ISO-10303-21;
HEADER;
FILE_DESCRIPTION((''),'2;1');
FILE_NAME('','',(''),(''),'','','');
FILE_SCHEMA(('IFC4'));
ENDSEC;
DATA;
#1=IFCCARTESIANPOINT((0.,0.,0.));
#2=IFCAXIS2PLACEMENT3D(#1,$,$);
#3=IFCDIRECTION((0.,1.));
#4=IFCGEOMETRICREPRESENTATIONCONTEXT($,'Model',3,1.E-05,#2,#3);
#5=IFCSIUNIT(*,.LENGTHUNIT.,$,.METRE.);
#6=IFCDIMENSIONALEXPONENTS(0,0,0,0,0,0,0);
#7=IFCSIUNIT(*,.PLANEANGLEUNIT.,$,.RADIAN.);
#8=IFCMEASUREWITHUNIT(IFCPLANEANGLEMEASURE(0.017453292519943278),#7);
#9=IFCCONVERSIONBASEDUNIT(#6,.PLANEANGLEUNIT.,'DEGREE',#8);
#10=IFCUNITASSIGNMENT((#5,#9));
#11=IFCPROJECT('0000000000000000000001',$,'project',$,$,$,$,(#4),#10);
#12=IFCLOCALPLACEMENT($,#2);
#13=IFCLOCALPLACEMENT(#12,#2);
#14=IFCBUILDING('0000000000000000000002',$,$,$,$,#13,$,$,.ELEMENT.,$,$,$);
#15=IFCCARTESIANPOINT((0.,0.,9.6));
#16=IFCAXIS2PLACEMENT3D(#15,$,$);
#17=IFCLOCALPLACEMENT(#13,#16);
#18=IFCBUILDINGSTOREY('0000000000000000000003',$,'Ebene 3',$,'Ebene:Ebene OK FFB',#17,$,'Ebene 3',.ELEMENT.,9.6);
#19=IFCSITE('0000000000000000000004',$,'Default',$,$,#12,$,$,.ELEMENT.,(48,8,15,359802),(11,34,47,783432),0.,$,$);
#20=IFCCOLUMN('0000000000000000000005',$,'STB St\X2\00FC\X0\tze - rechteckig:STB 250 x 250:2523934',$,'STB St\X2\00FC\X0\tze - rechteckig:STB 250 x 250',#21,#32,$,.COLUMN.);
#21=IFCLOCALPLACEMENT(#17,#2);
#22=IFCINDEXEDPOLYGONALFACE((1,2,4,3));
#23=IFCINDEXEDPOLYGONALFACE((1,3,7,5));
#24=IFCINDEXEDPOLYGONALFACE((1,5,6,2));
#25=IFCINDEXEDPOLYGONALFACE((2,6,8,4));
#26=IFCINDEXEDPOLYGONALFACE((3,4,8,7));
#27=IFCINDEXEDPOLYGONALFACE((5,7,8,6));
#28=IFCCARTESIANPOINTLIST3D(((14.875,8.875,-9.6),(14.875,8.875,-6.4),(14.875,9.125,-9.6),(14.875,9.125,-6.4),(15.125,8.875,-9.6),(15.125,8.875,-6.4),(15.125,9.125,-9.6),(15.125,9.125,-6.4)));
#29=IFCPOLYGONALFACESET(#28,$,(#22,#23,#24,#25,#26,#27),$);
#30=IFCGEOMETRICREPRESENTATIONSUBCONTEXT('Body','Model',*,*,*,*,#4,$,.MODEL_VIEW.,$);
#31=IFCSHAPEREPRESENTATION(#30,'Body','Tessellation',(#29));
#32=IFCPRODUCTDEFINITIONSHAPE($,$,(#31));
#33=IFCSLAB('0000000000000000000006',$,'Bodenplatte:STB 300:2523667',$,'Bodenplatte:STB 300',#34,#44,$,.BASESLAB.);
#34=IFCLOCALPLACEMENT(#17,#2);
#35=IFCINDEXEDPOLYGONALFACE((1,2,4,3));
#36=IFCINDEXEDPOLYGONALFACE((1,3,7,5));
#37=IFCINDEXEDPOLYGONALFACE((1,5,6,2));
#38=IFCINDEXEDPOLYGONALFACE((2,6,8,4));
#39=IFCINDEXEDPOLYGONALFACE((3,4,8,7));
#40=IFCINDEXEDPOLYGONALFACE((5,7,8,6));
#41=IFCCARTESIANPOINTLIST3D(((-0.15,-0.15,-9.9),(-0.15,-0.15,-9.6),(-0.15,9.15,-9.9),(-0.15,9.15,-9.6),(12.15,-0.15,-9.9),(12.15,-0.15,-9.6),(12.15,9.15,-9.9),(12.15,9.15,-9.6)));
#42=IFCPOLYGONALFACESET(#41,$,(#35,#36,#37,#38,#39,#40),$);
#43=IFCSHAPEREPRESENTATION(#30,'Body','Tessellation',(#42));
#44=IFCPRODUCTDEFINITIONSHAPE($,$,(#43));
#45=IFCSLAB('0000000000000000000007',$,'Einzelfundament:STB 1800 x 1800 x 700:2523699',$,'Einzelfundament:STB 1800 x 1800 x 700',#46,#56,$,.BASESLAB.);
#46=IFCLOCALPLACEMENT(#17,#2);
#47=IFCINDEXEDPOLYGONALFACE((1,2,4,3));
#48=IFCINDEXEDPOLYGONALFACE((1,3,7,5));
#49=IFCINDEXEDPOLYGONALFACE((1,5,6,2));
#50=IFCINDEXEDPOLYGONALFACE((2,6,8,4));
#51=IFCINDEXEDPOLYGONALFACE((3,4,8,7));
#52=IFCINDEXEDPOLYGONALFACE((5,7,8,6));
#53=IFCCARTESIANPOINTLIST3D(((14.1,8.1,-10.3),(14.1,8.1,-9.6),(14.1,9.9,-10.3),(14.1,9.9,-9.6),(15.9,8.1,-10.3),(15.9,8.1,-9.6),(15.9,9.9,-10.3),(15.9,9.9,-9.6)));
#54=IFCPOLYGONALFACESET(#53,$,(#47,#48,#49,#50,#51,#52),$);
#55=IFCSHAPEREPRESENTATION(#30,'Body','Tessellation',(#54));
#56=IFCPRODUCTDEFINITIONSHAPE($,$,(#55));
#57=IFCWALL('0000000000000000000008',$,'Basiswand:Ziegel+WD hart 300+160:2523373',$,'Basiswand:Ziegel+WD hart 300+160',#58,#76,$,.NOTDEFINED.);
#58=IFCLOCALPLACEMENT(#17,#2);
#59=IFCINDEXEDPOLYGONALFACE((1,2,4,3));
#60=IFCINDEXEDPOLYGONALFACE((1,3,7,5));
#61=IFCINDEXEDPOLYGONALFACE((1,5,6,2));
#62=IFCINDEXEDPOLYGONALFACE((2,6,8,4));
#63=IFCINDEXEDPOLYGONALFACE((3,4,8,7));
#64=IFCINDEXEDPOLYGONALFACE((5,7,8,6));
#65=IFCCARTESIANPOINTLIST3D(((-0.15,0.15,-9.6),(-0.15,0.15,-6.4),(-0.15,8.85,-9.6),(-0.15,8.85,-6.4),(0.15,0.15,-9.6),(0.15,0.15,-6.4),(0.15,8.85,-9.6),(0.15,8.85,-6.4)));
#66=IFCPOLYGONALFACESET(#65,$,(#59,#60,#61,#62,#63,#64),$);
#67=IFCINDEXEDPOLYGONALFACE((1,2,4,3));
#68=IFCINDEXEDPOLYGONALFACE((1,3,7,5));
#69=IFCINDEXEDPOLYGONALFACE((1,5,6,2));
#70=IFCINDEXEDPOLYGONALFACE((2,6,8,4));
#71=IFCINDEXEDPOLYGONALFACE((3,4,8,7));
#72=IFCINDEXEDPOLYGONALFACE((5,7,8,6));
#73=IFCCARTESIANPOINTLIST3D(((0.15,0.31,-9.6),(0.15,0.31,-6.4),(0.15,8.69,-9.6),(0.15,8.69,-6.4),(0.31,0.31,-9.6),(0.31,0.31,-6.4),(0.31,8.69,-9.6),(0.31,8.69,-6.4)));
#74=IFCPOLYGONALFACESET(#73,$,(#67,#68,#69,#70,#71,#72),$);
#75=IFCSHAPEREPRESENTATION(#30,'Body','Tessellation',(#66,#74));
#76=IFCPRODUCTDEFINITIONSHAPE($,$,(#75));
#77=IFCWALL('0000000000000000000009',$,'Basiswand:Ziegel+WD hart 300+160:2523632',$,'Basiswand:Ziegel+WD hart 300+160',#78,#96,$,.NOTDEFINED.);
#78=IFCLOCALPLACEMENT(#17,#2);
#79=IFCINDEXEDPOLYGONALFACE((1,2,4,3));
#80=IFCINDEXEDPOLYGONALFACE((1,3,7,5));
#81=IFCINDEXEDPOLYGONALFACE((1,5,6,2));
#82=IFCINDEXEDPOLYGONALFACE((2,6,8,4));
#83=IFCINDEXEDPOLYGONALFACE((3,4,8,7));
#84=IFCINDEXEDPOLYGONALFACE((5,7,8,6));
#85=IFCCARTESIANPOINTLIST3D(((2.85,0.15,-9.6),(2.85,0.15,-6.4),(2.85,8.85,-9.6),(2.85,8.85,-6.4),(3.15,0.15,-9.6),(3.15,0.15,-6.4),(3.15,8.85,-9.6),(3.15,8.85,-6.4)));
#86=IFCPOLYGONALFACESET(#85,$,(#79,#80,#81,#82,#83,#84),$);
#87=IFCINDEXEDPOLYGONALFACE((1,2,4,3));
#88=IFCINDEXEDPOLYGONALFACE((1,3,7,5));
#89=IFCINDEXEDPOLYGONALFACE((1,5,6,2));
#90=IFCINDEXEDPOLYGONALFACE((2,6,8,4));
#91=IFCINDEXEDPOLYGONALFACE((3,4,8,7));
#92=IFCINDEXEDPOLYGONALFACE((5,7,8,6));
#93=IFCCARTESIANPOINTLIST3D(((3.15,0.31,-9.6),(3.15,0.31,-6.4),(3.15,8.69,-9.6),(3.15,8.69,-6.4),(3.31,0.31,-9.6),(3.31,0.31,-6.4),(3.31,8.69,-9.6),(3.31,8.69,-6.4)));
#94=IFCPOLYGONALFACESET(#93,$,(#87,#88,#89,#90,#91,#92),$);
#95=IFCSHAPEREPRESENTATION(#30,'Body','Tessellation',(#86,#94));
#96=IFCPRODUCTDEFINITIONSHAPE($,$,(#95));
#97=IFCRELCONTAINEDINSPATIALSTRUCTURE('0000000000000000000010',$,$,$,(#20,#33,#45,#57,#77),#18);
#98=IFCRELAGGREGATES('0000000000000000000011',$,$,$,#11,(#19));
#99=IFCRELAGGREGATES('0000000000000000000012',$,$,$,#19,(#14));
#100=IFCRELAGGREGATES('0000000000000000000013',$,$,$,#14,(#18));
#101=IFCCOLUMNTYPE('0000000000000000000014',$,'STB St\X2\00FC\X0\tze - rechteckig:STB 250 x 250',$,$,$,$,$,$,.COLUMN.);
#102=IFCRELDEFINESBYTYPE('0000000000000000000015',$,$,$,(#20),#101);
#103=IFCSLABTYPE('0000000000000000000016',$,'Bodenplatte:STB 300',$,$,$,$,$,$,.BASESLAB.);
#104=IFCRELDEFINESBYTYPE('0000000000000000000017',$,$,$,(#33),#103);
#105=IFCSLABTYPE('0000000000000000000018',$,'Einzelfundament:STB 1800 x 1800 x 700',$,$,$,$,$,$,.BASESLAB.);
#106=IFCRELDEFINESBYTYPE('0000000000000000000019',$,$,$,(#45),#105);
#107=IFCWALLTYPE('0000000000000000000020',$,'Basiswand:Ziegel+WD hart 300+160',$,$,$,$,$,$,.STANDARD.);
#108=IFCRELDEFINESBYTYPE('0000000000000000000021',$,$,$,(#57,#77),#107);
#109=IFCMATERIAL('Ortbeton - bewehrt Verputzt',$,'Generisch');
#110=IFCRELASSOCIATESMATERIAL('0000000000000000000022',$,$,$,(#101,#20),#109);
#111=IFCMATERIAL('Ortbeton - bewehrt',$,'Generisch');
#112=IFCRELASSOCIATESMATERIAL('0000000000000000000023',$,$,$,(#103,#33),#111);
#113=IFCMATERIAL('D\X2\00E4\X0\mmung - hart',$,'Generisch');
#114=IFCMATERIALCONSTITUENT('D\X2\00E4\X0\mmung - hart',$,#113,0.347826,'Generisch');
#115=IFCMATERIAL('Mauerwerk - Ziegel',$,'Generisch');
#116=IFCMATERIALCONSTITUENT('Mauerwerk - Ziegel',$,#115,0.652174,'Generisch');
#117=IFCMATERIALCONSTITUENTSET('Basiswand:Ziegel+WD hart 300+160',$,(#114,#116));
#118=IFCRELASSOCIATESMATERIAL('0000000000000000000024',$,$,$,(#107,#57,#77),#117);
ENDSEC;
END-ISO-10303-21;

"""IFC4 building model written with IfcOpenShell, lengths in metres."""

from ifc_helpers import new_model, entity, si_unit, converted_unit, direction, frame, origin, place, context, subcontext, project, spatial, indexed_curve, outline, extrude, source, transform, mapped, material, constituent, constituent_set, type_object, type_shapes, element, save


model = new_model("IFC4")

# Units and contexts
model_context = context("Model", 3, precision=1e-05, world=origin(), true_north=direction((0.0, 1.0)))
body_context = subcontext(model_context, "Body", "Model", "MODEL_VIEW")
ifc_project = project(units=[si_unit("LENGTHUNIT", "METRE"), converted_unit("PLANEANGLEUNIT", "DEGREE", entity("IfcPlaneAngleMeasure", 0.017453292519943278), si_unit("PLANEANGLEUNIT", "RADIAN"), dimensions=[0, 0, 0, 0, 0, 0, 0])], contexts=[model_context])

# Site, building, storey
site_placement = place(None, origin())
site = spatial("IfcSite", under=ifc_project, at=site_placement, Name="Default", CompositionType="ELEMENT", RefLatitude=(48, 8, 15, 359802), RefLongitude=(11, 34, 47, 783432), RefElevation=0.0)
building_placement = place(site_placement, origin())
building = spatial("IfcBuilding", under=site, at=building_placement, CompositionType="ELEMENT")
storey_placement = place(building_placement, frame((0.0, 0.0, 9.6)))
storey = spatial("IfcBuildingStorey", under=building, at=storey_placement, Name="Ebene 3", ObjectType="Ebene:Ebene OK FFB", LongName="Ebene 3", CompositionType="ELEMENT", Elevation=9.6)

# Column
ifc_material_1 = material(Name="Ortbeton - bewehrt Verputzt", Category="Generisch")
column_type = type_object("IfcColumnType", Name="STB Stütze - rechteckig:STB 250 x 250", PredefinedType="COLUMN", material=ifc_material_1)
shared_shape = source(origin(), body_context, "Body", "SweptSolid", [
    extrude(outline(indexed_curve([(-0.125, -0.125), (0.125, -0.125), (0.125, 0.125), (-0.125, 0.125), (-0.125, -0.125)], self_intersect=False)), frame((0.0, 0.0, 0.0), z_axis=(0.0, 0.0, 1.0), x_axis=(-1.0, 0.0, 0.0)), (0.0, 0.0, 1.0), 3.2),
])
type_shapes(column_type, [shared_shape])
column_placement = place(storey_placement, frame((15.0, 9.0, -9.6)))
element("IfcColumn", 1, at=column_placement, inside=storey, type_object=column_type, material=ifc_material_1, Name="STB Stütze - rechteckig:STB 250 x 250:2523934", ObjectType="STB Stütze - rechteckig:STB 250 x 250", PredefinedType="COLUMN", context=body_context, shape_type="MappedRepresentation", body=[
    mapped(shared_shape, transform((0.0, 0.0, 0.0), scale=1.0)),
])

# Slabs
ifc_material_2 = material(Name="Ortbeton - bewehrt", Category="Generisch")
slab_type_1 = type_object("IfcSlabType", Name="Bodenplatte:STB 300", PredefinedType="BASESLAB", material=ifc_material_2)
slab_1_placement = place(storey_placement, origin())
element("IfcSlab", 2, at=slab_1_placement, inside=storey, type_object=slab_type_1, material=ifc_material_2, Name="Bodenplatte:STB 300:2523667", ObjectType="Bodenplatte:STB 300", PredefinedType="BASESLAB", context=body_context, shape_type="SweptSolid", body=[
    extrude(outline(indexed_curve([(-4.65, -6.15), (4.65, -6.15), (4.65, 6.15), (-4.65, 6.15), (-4.65, -6.15)], self_intersect=False)), frame((6.0, 4.5, -9.6), z_axis=(0.0, 0.0, -1.0), x_axis=(0.0, 1.0, 0.0)), (0.0, 0.0, 1.0), 0.3),
])
slab_type_2 = type_object("IfcSlabType", Name="Einzelfundament:STB 1800 x 1800 x 700", PredefinedType="BASESLAB")
slab_2_placement = place(storey_placement, origin())
element("IfcSlab", 3, at=slab_2_placement, inside=storey, type_object=slab_type_2, Name="Einzelfundament:STB 1800 x 1800 x 700:2523699", ObjectType="Einzelfundament:STB 1800 x 1800 x 700", PredefinedType="BASESLAB", context=body_context, shape_type="SweptSolid", body=[
    extrude(outline(indexed_curve([(-0.9, -0.9), (0.9, -0.9), (0.9, 0.9), (-0.9, 0.9), (-0.9, -0.9)], self_intersect=False)), frame((15.0, 9.0, -10.3), z_axis=(0.0, 0.0, 1.0), x_axis=(-1.0, 0.0, 0.0)), (0.0, 0.0, 1.0), 0.7),
])

# Shared definitions
ifc_material_3 = material(Name="Dämmung - hart", Category="Generisch")
ifc_constituent_1 = constituent(ifc_material_3, Name="Dämmung - hart", Category="Generisch", fraction=0.347826)
ifc_material_4 = material(Name="Mauerwerk - Ziegel", Category="Generisch")
ifc_constituent_2 = constituent(ifc_material_4, Name="Mauerwerk - Ziegel", Category="Generisch", fraction=0.652174)
ifc_constituent_set = constituent_set(constituents=[ifc_constituent_1, ifc_constituent_2], Name="Basiswand:Ziegel+WD hart 300+160")
wall_type = type_object("IfcWallType", Name="Basiswand:Ziegel+WD hart 300+160", PredefinedType="STANDARD", material=ifc_constituent_set)

# Walls
wall_1_placement = place(storey_placement, frame((0.08, 8.69, -9.6), z_axis=(0.0, 0.0, 1.0), x_axis=(0.0, -1.0, 0.0)))
element("IfcWall", 4, at=wall_1_placement, inside=storey, type_object=wall_type, material=ifc_constituent_set, Name="Basiswand:Ziegel+WD hart 300+160:2523373", ObjectType="Basiswand:Ziegel+WD hart 300+160", PredefinedType="NOTDEFINED", context=body_context, shape_type="SweptSolid", body=[
    extrude(outline(indexed_curve([(-0.15, -4.35), (0.15, -4.35), (0.15, 4.35), (-0.15, 4.35), (-0.15, -4.35)], self_intersect=False)), frame((4.19, -0.08, 0.0), z_axis=(0.0, 0.0, 1.0), x_axis=(0.0, 1.0, 0.0)), (0.0, 0.0, 1.0), 3.2),
    extrude(outline(indexed_curve([(-0.08, -4.19), (0.08, -4.19), (0.08, 4.19), (-0.08, 4.19), (-0.08, -4.19)], self_intersect=False)), frame((4.19, 0.15, 0.0), z_axis=(0.0, 0.0, 1.0), x_axis=(0.0, -1.0, 0.0)), (0.0, 0.0, 1.0), 3.2),
])
wall_2_placement = place(storey_placement, frame((3.08, 8.69, -9.6), z_axis=(0.0, 0.0, 1.0), x_axis=(0.0, -1.0, 0.0)))
element("IfcWall", 5, at=wall_2_placement, inside=storey, type_object=wall_type, material=ifc_constituent_set, Name="Basiswand:Ziegel+WD hart 300+160:2523632", ObjectType="Basiswand:Ziegel+WD hart 300+160", PredefinedType="NOTDEFINED", context=body_context, shape_type="SweptSolid", body=[
    extrude(outline(indexed_curve([(-0.15, -4.35), (0.15, -4.35), (0.15, 4.35), (-0.15, 4.35), (-0.15, -4.35)], self_intersect=False)), frame((4.19, -0.08, 0.0), z_axis=(0.0, 0.0, 1.0), x_axis=(0.0, 1.0, 0.0)), (0.0, 0.0, 1.0), 3.2),
    extrude(outline(indexed_curve([(-0.08, -4.19), (0.08, -4.19), (0.08, 4.19), (-0.08, 4.19), (-0.08, -4.19)], self_intersect=False)), frame((4.19, 0.15, 0.0), z_axis=(0.0, 0.0, 1.0), x_axis=(0.0, -1.0, 0.0)), (0.0, 0.0, 1.0), 3.2),
])

save(model, "model.ifc")
